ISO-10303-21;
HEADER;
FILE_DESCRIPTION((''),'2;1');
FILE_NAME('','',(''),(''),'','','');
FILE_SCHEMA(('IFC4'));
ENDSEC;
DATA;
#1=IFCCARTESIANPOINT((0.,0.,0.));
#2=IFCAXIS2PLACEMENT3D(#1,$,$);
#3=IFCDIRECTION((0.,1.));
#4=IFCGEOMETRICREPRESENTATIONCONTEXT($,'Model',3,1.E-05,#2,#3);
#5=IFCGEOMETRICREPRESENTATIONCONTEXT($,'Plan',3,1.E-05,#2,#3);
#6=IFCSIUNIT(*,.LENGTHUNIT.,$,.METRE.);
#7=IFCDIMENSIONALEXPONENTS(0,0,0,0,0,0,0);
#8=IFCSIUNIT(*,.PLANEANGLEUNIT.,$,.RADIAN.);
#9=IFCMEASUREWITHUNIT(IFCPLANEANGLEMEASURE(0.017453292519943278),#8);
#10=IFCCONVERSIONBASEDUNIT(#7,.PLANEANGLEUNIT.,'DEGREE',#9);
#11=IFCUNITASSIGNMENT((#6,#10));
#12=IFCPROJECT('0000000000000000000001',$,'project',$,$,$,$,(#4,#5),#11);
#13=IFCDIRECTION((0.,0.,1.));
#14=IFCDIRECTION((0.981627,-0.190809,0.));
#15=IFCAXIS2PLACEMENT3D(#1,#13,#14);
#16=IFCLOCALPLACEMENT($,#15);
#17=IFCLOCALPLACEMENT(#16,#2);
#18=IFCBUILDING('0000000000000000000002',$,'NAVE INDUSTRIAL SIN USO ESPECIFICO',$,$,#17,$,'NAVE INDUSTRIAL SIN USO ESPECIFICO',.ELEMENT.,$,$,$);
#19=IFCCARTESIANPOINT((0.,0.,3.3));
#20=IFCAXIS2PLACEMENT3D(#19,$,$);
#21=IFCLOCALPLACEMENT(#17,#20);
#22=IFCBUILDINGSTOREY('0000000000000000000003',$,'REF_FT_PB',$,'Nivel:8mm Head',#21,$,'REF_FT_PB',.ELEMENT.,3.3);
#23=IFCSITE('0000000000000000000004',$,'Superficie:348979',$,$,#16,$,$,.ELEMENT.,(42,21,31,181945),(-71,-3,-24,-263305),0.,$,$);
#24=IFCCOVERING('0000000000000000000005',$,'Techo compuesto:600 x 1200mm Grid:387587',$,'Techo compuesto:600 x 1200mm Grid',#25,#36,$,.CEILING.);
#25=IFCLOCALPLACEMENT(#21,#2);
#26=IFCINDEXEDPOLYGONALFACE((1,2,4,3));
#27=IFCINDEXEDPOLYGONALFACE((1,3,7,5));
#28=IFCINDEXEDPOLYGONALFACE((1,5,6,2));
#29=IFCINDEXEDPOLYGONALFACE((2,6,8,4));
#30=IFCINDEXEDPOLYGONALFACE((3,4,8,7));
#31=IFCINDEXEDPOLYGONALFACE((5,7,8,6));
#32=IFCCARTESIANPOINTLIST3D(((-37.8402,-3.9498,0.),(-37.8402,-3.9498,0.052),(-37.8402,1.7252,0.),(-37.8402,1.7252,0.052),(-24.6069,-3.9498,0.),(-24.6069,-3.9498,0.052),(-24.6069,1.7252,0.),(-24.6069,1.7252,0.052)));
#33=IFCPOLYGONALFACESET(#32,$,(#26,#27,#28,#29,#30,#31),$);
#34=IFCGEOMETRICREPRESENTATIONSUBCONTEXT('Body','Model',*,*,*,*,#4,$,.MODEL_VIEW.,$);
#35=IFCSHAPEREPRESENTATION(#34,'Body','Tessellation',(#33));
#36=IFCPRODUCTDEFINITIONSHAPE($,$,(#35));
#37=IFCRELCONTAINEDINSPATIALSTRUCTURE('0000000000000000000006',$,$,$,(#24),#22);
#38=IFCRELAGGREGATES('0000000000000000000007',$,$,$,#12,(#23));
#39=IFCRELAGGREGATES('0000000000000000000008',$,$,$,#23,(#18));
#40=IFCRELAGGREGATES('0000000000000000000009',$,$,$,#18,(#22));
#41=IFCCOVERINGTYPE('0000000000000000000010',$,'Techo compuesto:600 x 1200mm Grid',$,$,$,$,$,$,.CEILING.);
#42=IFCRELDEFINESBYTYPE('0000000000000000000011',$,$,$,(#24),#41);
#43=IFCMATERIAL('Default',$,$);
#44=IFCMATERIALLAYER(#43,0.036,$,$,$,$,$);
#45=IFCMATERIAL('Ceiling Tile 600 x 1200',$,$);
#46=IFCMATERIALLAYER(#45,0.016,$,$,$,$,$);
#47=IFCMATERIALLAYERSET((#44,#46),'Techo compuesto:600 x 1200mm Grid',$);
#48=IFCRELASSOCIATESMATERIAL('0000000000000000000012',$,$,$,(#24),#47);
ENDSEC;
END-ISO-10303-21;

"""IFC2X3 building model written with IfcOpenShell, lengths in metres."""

from ifc_helpers import new_model, entity, si_unit, converted_unit, direction, frame, frame_2d, origin, place, context, subcontext, project, spatial, rectangle, extrude, material, layer, layer_set, layer_usage, type_object, element, save


model = new_model("IFC2X3")

# Units and contexts
model_context = context("Model", 3, precision=1e-05, world=origin(), true_north=direction((0.0, 1.0)))
plan_context = context("Plan", 3, precision=1e-05, world=origin(), true_north=direction((0.0, 1.0)))
body_context = subcontext(model_context, "Body", "Model", "MODEL_VIEW")
ifc_project = project(units=[si_unit("LENGTHUNIT", "METRE"), converted_unit("PLANEANGLEUNIT", "DEGREE", entity("IfcPlaneAngleMeasure", 0.017453292519943278), si_unit("PLANEANGLEUNIT", "RADIAN"), dimensions=[0, 0, 0, 0, 0, 0, 0])], contexts=[model_context, plan_context])

# Site, building, storey
site_placement = place(None, frame((0.0, 0.0, 0.0), z_axis=(0.0, 0.0, 1.0), x_axis=(0.981627, -0.190809, 0.0)))
site = spatial("IfcSite", under=ifc_project, at=site_placement, Name="Superficie:348979", CompositionType="ELEMENT", RefLatitude=(42, 21, 31, 181945), RefLongitude=(-71, -3, -24, -263305), RefElevation=0.0)
building_placement = place(site_placement, origin())
building = spatial("IfcBuilding", under=site, at=building_placement, Name="NAVE INDUSTRIAL SIN USO ESPECIFICO", LongName="NAVE INDUSTRIAL SIN USO ESPECIFICO", CompositionType="ELEMENT")
storey_placement = place(building_placement, frame((0.0, 0.0, 3.3)))
storey = spatial("IfcBuildingStorey", under=building, at=storey_placement, Name="REF_FT_PB", ObjectType="Nivel:8mm Head", LongName="REF_FT_PB", CompositionType="ELEMENT", Elevation=3.3)

# Covering
ifc_material_1 = material(Name="Default")
ifc_layer_1 = layer(ifc_material_1, 0.036)
ifc_material_2 = material(Name="Ceiling Tile 600 x 1200")
ifc_layer_2 = layer(ifc_material_2, 0.016)
ifc_layer_set_1 = layer_set([ifc_layer_1, ifc_layer_2], Name="Techo compuesto:600 x 1200mm Grid")
ifc_layer_usage_1 = layer_usage(ifc_layer_set_1, "AXIS3", "NEGATIVE", 0.052)
covering_type_1 = type_object("IfcCoveringType", Name="Techo compuesto:600 x 1200mm Grid", PredefinedType="CEILING")
covering_1_placement = place(storey_placement, frame((-37.8402, -3.9498, 0.0)))
element("IfcCovering", 1, at=covering_1_placement, inside=storey, type_object=covering_type_1, material=ifc_layer_usage_1, Name="Techo compuesto:600 x 1200mm Grid:387587", ObjectType="Techo compuesto:600 x 1200mm Grid", PredefinedType="CEILING", context=body_context, shape_type="SweptSolid", body=[
    extrude(rectangle(XDim=13.2333, YDim=5.675, at=frame_2d((0.0, 0.0), x_axis=(1.0, 0.0))), frame((6.6167, 2.8375, 0.0)), (0.0, 0.0, 1.0), 0.052),
])

save(model, "model.ifc")
